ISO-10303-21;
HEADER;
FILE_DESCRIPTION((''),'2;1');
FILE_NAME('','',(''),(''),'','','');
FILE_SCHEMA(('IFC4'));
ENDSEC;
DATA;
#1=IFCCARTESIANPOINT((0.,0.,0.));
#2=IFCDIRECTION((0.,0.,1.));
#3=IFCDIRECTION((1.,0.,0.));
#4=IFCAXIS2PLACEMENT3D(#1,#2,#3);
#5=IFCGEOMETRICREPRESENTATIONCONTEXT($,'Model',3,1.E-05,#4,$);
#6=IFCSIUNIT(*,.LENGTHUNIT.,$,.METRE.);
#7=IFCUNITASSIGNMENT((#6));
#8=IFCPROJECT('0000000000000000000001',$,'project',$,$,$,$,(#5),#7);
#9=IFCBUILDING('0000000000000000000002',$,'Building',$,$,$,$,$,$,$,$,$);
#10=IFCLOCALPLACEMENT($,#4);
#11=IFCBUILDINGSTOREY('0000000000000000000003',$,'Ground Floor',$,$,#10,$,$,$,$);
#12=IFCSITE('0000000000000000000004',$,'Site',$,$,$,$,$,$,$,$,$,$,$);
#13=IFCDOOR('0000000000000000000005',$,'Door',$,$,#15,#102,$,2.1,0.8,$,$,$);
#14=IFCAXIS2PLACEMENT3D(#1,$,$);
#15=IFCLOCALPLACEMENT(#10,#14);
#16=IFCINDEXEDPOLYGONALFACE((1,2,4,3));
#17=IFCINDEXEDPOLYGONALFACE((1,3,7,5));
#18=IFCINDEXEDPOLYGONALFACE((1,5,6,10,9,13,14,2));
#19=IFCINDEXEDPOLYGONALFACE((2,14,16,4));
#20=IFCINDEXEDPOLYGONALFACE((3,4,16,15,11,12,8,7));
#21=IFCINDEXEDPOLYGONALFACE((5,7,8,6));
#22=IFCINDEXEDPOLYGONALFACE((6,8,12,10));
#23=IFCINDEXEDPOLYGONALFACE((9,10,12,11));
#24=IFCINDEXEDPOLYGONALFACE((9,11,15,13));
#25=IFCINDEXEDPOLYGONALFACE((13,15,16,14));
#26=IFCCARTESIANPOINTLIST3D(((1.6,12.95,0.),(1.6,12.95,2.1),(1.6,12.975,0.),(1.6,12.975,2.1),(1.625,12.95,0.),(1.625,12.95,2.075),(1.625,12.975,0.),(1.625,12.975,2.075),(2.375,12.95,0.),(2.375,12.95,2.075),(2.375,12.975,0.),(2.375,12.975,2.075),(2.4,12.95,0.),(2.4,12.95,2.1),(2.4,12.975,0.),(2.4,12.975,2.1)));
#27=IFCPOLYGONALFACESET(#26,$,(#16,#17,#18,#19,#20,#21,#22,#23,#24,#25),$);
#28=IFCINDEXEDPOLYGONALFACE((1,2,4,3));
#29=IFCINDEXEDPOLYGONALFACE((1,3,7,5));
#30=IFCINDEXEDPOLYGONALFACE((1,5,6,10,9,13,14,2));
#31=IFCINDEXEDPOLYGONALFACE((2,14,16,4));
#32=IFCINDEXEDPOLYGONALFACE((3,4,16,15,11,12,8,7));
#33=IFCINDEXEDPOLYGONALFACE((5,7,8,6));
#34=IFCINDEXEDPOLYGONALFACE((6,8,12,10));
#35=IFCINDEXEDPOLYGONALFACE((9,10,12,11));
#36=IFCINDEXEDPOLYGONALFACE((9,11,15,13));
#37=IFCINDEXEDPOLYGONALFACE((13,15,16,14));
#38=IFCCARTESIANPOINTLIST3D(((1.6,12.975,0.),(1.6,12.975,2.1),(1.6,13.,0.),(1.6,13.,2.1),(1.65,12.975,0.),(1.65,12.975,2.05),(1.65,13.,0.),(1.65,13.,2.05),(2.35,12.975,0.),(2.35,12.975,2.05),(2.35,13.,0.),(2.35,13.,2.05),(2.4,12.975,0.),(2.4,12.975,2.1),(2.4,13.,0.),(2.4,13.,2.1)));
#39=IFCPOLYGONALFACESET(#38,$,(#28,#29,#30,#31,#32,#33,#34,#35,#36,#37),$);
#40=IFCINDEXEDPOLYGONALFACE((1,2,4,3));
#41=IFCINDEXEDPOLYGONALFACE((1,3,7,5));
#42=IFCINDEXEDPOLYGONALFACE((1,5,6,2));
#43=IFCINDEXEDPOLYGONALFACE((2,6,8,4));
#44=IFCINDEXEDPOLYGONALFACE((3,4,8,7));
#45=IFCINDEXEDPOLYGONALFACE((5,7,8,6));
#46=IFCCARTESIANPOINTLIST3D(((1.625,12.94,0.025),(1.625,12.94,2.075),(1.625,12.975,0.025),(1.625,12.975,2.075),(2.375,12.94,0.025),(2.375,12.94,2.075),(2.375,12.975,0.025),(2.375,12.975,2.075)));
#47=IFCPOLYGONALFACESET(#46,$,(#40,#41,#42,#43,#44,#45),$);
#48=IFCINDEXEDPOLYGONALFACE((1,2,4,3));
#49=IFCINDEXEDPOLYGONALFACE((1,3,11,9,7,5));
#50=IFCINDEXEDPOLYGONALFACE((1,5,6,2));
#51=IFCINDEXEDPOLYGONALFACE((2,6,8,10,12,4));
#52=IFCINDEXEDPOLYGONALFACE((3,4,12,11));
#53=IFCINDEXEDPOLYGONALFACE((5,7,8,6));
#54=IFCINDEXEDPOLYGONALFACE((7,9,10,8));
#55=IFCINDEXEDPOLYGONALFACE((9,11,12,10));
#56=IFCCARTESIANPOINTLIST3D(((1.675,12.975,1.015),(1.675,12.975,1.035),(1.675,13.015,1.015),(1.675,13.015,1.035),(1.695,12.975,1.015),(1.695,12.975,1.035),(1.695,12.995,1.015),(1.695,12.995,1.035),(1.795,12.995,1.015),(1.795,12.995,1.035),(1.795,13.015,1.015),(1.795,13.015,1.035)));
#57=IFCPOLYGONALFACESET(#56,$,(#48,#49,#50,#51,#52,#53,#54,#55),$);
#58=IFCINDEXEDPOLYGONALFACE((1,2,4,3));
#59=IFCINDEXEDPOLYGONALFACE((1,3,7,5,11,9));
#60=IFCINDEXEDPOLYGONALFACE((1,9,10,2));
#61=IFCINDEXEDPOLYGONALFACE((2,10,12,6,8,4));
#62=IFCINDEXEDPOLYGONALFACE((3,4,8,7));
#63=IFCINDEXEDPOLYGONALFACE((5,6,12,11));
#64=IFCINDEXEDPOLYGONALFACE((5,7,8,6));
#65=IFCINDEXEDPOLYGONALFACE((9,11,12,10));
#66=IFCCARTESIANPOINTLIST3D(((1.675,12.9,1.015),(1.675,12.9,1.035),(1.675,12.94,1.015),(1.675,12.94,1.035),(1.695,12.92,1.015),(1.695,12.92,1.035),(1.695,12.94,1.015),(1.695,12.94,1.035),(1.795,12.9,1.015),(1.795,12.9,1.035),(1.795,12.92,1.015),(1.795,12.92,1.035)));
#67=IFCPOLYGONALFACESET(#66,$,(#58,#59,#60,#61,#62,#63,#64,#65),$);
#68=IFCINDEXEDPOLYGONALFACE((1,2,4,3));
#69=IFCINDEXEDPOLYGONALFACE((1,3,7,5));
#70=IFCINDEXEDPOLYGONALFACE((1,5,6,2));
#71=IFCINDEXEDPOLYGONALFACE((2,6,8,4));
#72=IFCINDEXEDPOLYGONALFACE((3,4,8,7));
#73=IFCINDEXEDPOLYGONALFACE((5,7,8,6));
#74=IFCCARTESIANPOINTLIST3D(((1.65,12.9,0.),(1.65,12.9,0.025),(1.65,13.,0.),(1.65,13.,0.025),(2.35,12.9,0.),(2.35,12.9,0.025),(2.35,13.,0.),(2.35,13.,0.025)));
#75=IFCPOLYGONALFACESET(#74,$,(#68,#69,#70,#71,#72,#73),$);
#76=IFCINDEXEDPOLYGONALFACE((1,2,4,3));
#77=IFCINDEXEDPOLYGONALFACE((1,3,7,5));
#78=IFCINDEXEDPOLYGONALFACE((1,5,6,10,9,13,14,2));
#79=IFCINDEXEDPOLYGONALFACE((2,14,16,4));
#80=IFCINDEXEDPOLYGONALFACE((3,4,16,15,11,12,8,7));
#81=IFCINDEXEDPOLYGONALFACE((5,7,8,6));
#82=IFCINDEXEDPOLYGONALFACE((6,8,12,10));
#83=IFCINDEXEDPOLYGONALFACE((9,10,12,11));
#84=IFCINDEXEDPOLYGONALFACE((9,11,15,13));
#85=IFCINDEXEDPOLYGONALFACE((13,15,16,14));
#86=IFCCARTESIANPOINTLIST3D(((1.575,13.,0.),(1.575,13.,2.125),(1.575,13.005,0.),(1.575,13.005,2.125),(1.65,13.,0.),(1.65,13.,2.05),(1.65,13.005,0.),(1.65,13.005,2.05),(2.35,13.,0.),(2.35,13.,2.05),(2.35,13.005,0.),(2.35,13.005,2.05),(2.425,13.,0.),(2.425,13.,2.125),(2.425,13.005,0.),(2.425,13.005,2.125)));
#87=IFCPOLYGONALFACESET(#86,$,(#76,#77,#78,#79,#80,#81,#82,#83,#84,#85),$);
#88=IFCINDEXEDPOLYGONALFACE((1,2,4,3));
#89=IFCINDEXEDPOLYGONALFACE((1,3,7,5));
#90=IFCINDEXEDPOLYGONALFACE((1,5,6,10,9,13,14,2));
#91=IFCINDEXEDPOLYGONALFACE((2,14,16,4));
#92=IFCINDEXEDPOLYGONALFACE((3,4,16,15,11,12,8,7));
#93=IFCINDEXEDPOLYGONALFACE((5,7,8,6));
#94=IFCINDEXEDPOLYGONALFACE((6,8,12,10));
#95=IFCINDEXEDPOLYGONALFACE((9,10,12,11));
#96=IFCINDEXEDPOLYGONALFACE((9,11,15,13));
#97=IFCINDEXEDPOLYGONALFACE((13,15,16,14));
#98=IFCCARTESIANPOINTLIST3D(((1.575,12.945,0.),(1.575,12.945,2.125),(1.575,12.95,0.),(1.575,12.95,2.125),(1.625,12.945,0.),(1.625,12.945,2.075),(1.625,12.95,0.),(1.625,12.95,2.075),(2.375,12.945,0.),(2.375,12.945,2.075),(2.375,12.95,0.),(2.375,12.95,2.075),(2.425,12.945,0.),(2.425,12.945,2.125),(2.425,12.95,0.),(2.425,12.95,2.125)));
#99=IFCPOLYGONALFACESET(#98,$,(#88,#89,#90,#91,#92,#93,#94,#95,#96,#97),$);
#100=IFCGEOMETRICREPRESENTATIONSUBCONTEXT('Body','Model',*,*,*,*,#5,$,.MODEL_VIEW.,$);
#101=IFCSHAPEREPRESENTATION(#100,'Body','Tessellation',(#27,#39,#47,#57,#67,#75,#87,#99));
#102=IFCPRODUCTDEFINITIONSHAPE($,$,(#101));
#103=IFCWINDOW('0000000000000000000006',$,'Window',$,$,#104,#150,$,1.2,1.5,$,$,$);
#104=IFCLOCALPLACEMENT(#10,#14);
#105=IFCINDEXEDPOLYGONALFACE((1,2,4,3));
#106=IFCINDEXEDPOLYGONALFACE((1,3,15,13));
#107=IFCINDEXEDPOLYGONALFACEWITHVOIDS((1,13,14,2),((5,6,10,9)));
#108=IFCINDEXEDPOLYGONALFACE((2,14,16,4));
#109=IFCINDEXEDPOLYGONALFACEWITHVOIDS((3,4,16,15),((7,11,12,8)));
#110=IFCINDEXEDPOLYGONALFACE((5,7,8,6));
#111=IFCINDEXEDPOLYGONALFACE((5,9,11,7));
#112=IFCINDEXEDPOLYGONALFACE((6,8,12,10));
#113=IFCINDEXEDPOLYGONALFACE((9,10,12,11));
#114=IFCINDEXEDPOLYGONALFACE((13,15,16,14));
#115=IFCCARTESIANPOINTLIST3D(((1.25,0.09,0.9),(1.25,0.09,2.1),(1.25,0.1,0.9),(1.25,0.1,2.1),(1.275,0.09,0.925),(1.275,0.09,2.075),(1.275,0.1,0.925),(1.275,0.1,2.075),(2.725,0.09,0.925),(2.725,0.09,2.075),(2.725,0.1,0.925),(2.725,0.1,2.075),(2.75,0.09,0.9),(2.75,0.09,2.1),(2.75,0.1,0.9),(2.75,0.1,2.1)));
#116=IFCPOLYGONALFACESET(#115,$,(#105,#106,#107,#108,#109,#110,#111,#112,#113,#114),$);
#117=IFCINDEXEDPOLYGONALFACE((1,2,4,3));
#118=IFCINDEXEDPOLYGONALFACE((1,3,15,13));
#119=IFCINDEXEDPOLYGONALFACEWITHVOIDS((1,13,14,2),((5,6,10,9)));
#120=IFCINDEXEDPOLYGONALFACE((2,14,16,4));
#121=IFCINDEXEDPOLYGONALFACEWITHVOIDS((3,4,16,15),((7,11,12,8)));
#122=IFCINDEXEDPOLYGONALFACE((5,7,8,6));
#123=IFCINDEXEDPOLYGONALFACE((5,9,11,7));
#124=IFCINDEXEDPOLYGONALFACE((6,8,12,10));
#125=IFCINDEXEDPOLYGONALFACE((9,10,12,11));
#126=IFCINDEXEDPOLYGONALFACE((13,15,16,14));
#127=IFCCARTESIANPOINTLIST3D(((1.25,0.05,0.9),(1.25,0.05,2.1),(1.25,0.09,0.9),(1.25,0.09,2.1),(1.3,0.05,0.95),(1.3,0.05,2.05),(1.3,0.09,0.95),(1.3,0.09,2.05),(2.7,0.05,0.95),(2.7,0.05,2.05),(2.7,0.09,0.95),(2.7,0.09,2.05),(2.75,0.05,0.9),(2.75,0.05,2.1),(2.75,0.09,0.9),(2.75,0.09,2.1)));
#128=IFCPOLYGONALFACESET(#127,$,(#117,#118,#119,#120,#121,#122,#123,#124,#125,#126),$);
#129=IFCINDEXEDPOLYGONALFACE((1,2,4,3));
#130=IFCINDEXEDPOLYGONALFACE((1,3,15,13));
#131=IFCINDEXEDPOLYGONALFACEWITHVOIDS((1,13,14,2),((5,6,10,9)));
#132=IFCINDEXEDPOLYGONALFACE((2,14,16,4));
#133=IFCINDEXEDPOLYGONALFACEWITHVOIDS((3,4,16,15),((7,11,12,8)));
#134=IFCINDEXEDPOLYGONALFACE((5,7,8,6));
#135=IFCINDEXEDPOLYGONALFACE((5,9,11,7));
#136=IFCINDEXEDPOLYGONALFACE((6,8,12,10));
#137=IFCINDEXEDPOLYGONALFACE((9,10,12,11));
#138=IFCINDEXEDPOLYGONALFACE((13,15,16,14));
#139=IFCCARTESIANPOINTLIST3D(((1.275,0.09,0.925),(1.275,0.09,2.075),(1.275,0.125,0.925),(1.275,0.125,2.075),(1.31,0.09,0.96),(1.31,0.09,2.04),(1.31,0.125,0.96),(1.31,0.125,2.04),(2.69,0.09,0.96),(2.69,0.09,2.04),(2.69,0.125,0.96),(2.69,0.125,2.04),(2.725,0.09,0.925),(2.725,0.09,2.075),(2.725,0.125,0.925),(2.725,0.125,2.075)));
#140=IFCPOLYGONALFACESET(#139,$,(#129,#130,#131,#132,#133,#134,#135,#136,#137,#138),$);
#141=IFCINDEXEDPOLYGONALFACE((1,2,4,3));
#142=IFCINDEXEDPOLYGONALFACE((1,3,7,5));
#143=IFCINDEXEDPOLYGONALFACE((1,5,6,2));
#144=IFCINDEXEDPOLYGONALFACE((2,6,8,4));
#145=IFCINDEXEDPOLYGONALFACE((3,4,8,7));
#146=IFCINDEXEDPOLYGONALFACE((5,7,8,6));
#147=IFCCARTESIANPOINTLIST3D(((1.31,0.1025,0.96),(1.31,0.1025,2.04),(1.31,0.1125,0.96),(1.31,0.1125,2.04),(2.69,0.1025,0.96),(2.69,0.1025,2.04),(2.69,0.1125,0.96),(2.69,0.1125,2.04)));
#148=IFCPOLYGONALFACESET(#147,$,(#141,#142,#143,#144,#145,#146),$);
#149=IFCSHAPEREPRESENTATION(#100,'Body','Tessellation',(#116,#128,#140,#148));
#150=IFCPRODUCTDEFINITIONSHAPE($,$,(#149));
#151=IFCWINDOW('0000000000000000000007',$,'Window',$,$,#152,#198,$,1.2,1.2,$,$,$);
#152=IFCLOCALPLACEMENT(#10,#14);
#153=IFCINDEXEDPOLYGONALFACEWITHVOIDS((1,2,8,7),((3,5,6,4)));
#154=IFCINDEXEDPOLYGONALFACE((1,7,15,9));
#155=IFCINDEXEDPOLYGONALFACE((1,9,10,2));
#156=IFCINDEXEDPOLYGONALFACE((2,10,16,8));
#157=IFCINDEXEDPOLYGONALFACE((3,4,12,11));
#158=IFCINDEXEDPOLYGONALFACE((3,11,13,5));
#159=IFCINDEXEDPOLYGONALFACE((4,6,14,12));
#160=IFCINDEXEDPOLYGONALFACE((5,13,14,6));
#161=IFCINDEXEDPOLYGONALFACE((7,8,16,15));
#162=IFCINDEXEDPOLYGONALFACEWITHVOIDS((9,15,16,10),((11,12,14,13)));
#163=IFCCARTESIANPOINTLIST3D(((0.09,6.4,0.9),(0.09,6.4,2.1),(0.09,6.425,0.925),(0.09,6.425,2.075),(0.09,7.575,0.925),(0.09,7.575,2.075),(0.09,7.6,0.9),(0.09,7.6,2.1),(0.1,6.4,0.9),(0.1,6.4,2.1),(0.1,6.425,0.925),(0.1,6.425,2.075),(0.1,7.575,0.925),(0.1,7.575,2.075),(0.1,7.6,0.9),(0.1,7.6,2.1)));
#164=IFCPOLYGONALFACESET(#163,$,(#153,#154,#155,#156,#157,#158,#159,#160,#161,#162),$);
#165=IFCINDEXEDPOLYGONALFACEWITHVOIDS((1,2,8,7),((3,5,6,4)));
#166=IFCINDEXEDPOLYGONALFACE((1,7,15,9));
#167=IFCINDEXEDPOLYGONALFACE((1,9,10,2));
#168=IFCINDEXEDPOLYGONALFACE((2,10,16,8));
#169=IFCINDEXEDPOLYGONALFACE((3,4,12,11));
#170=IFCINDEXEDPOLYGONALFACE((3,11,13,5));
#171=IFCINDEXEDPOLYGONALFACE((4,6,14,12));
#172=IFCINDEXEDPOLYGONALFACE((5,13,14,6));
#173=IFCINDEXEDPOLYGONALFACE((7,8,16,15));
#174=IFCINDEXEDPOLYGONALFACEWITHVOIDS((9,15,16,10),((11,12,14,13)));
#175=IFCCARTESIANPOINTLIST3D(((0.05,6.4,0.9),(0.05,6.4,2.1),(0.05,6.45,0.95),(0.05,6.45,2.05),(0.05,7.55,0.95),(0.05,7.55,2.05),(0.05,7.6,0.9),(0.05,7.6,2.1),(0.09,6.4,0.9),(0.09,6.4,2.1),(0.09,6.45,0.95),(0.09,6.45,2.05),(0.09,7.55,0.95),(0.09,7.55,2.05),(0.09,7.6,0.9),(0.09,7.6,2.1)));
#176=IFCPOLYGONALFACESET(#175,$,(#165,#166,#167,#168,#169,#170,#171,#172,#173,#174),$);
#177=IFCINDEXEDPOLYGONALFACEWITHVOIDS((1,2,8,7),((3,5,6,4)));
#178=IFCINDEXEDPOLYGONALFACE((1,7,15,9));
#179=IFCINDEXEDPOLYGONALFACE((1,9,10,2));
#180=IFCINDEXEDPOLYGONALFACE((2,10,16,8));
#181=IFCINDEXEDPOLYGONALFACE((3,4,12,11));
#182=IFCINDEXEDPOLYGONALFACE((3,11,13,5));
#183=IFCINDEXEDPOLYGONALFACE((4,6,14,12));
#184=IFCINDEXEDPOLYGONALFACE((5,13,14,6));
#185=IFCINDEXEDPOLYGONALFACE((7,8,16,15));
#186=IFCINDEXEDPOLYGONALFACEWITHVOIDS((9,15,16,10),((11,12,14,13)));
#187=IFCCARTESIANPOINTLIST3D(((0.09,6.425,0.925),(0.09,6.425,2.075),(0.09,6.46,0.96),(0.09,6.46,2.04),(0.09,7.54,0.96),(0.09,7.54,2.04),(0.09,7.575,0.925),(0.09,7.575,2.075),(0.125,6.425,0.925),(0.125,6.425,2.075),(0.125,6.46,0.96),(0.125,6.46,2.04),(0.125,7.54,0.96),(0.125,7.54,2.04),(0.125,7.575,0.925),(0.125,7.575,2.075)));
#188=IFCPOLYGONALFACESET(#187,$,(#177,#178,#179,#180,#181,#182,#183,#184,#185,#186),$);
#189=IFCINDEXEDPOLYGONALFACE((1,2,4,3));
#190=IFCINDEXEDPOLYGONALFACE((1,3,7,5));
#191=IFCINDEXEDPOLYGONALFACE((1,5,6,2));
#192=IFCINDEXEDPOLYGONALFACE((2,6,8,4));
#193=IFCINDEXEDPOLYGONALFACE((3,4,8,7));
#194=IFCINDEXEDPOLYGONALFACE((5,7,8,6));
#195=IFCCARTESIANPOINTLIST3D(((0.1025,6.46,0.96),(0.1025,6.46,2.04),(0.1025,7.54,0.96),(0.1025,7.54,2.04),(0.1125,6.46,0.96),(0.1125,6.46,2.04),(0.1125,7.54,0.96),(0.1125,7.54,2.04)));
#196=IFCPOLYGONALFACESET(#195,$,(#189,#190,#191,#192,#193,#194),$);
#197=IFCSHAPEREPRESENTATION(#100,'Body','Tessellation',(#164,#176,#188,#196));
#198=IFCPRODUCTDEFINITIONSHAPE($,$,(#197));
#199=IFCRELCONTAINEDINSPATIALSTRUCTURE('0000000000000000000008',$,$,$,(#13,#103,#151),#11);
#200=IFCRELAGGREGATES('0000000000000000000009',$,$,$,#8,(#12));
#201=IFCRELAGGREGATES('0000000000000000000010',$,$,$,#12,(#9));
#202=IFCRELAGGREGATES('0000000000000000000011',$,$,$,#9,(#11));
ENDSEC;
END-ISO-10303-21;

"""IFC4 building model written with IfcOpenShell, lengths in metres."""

from ifc_helpers import new_model, si_unit, frame, origin_with_axes, place, context, subcontext, project, spatial, line, indexed_curve, outline, extrude, element, save


model = new_model("IFC4")

# Units and contexts
model_context = context("Model", 3, precision=1e-05, world=origin_with_axes())
body_context = subcontext(model_context, "Body", "Model", "MODEL_VIEW")
ifc_project = project(units=[si_unit("LENGTHUNIT", "METRE")], contexts=[model_context])

# Site, building, storey
site = spatial("IfcSite", under=ifc_project, Name="Site")
building = spatial("IfcBuilding", under=site, Name="Building")
storey_placement = place(None, origin_with_axes())
storey = spatial("IfcBuildingStorey", under=building, at=storey_placement, Name="Ground Floor")

# Door
door_1_placement = place(storey_placement, frame((2.4, 13.0, 0.0), z_axis=(0.0, 0.0, 1.0), x_axis=(-1.0, 0.0, 0.0)))
element("IfcDoor", 1, at=door_1_placement, inside=storey, Name="Door", OverallHeight=2.1, OverallWidth=0.8, context=body_context, shape_type="SweptSolid", body=[
    extrude(outline(indexed_curve([(0.0, 0.0), (0.0, 2.1), (0.8, 2.1), (0.8, 0.0), (0.775, 0.0), (0.775, 2.075), (0.025, 2.075), (0.025, 0.0)], segments=[line(1, 2, 3, 4, 5, 6, 7, 8, 1)])), frame((0.0, 0.025, 0.0), z_axis=(0.0, -1.0, 0.0), x_axis=(1.0, 0.0, 0.0)), (0.0, 0.0, -1.0), 0.025),
    extrude(outline(indexed_curve([(0.0, 0.0), (0.0, 2.1), (0.8, 2.1), (0.8, 0.0), (0.75, 0.0), (0.75, 2.05), (0.05, 2.05), (0.05, 0.0)], segments=[line(1, 2, 3, 4, 5, 6, 7, 8, 1)])), frame((0.0, 0.0, 0.0), z_axis=(0.0, -1.0, 0.0), x_axis=(1.0, 0.0, 0.0)), (0.0, 0.0, -1.0), 0.025),
    extrude(outline(indexed_curve([(0.0, 0.0), (0.75, 0.0), (0.75, 0.035), (0.0, 0.035)], segments=[line(1, 2, 3, 4, 1)])), frame((0.025, 0.025, 0.025), z_axis=(0.0, 0.0, 1.0), x_axis=(1.0, 0.0, 0.0)), (0.0, 0.0, 1.0), 2.05),
    extrude(outline(indexed_curve([(0.0, 0.0), (0.0, -0.04), (-0.12, -0.04), (-0.12, -0.02), (-0.02, -0.02), (-0.02, 0.0)], segments=[line(1, 2, 3, 4, 5, 6, 1)])), frame((0.725, 0.025, 1.015), z_axis=(0.0, 0.0, 1.0), x_axis=(1.0, 0.0, 0.0)), (0.0, 0.0, 1.0), 0.02),
    extrude(outline(indexed_curve([(0.0, 0.0), (0.0, 0.04), (-0.12, 0.04), (-0.12, 0.02), (-0.02, 0.02), (-0.02, 0.0)], segments=[line(1, 2, 3, 4, 5, 6, 1)])), frame((0.725, 0.06, 1.015), z_axis=(0.0, 0.0, 1.0), x_axis=(1.0, 0.0, 0.0)), (0.0, 0.0, 1.0), 0.02),
    extrude(outline(indexed_curve([(0.0, 0.0), (0.7, 0.0), (0.7, 0.1), (0.0, 0.1)], segments=[line(1, 2, 3, 4, 1)])), frame((0.05, 0.0, 0.0), z_axis=(0.0, 0.0, 1.0), x_axis=(1.0, 0.0, 0.0)), (0.0, 0.0, 1.0), 0.025),
    extrude(outline(indexed_curve([(0.0, 0.0), (0.0, 2.125), (0.85, 2.125), (0.85, 0.0), (0.775, 0.0), (0.775, 2.05), (0.075, 2.05), (0.075, 0.0)], segments=[line(1, 2, 3, 4, 5, 6, 7, 8, 1)])), frame((-0.025, -0.005, 0.0), z_axis=(0.0, -1.0, 0.0), x_axis=(1.0, 0.0, 0.0)), (0.0, 0.0, -1.0), 0.005),
    extrude(outline(indexed_curve([(0.0, 0.0), (0.0, 2.125), (0.85, 2.125), (0.85, 0.0), (0.8, 0.0), (0.8, 2.075), (0.05, 2.075), (0.05, 0.0)], segments=[line(1, 2, 3, 4, 5, 6, 7, 8, 1)])), frame((-0.025, 0.05, 0.0), z_axis=(0.0, -1.0, 0.0), x_axis=(1.0, 0.0, 0.0)), (0.0, 0.0, -1.0), 0.005),
])

# Windows
window_1_placement = place(storey_placement, frame((1.25, 0.0, 0.9), z_axis=(0.0, 0.0, 1.0), x_axis=(1.0, 0.0, 0.0)))
element("IfcWindow", 2, at=window_1_placement, inside=storey, Name="Window", OverallHeight=1.2, OverallWidth=1.5, context=body_context, shape_type="SweptSolid", body=[
    extrude(outline(indexed_curve([(0.0, 0.0), (1.5, 0.0), (1.5, 1.2), (0.0, 1.2)], segments=[line(1, 2, 3, 4, 1)]), holes=[indexed_curve([(0.025, 0.025), (1.475, 0.025), (1.475, 1.175), (0.025, 1.175)], segments=[line(1, 2, 3, 4, 1)])]), frame((0.0, 0.09, 0.0), z_axis=(0.0, -1.0, 0.0), x_axis=(1.0, 0.0, 0.0)), (0.0, 0.0, -1.0), 0.01),
    extrude(outline(indexed_curve([(0.0, 0.0), (1.5, 0.0), (1.5, 1.2), (0.0, 1.2)], segments=[line(1, 2, 3, 4, 1)]), holes=[indexed_curve([(0.05, 0.05), (1.45, 0.05), (1.45, 1.15), (0.05, 1.15)], segments=[line(1, 2, 3, 4, 1)])]), frame((0.0, 0.05, 0.0), z_axis=(0.0, -1.0, 0.0), x_axis=(1.0, 0.0, 0.0)), (0.0, 0.0, -1.0), 0.04),
    extrude(outline(indexed_curve([(0.0, 0.0), (1.45, 0.0), (1.45, 1.15), (0.0, 1.15)], segments=[line(1, 2, 3, 4, 1)]), holes=[indexed_curve([(0.035, 0.035), (1.415, 0.035), (1.415, 1.115), (0.035, 1.115)], segments=[line(1, 2, 3, 4, 1)])]), frame((0.025, 0.09, 0.025), z_axis=(0.0, -1.0, 0.0), x_axis=(1.0, 0.0, 0.0)), (0.0, 0.0, -1.0), 0.035),
    extrude(outline(indexed_curve([(0.035, 0.035), (1.415, 0.035), (1.415, 1.115), (0.035, 1.115)], segments=[line(1, 2, 3, 4, 1)])), frame((0.025, 0.1025, 0.025), z_axis=(0.0, -1.0, 0.0), x_axis=(1.0, 0.0, 0.0)), (0.0, 0.0, -1.0), 0.01),
])
window_2_placement = place(storey_placement, frame((0.0, 7.6, 0.9), z_axis=(0.0, 0.0, 1.0), x_axis=(0.0, -1.0, 0.0)))
element("IfcWindow", 3, at=window_2_placement, inside=storey, Name="Window", OverallHeight=1.2, OverallWidth=1.2, context=body_context, shape_type="SweptSolid", body=[
    extrude(outline(indexed_curve([(0.0, 0.0), (1.2, 0.0), (1.2, 1.2), (0.0, 1.2)], segments=[line(1, 2, 3, 4, 1)]), holes=[indexed_curve([(0.025, 0.025), (1.175, 0.025), (1.175, 1.175), (0.025, 1.175)], segments=[line(1, 2, 3, 4, 1)])]), frame((0.0, 0.09, 0.0), z_axis=(0.0, -1.0, 0.0), x_axis=(1.0, 0.0, 0.0)), (0.0, 0.0, -1.0), 0.01),
    extrude(outline(indexed_curve([(0.0, 0.0), (1.2, 0.0), (1.2, 1.2), (0.0, 1.2)], segments=[line(1, 2, 3, 4, 1)]), holes=[indexed_curve([(0.05, 0.05), (1.15, 0.05), (1.15, 1.15), (0.05, 1.15)], segments=[line(1, 2, 3, 4, 1)])]), frame((0.0, 0.05, 0.0), z_axis=(0.0, -1.0, 0.0), x_axis=(1.0, 0.0, 0.0)), (0.0, 0.0, -1.0), 0.04),
    extrude(outline(indexed_curve([(0.0, 0.0), (1.15, 0.0), (1.15, 1.15), (0.0, 1.15)], segments=[line(1, 2, 3, 4, 1)]), holes=[indexed_curve([(0.035, 0.035), (1.115, 0.035), (1.115, 1.115), (0.035, 1.115)], segments=[line(1, 2, 3, 4, 1)])]), frame((0.025, 0.09, 0.025), z_axis=(0.0, -1.0, 0.0), x_axis=(1.0, 0.0, 0.0)), (0.0, 0.0, -1.0), 0.035),
    extrude(outline(indexed_curve([(0.035, 0.035), (1.115, 0.035), (1.115, 1.115), (0.035, 1.115)], segments=[line(1, 2, 3, 4, 1)])), frame((0.025, 0.1025, 0.025), z_axis=(0.0, -1.0, 0.0), x_axis=(1.0, 0.0, 0.0)), (0.0, 0.0, -1.0), 0.01),
])

save(model, "model.ifc")
